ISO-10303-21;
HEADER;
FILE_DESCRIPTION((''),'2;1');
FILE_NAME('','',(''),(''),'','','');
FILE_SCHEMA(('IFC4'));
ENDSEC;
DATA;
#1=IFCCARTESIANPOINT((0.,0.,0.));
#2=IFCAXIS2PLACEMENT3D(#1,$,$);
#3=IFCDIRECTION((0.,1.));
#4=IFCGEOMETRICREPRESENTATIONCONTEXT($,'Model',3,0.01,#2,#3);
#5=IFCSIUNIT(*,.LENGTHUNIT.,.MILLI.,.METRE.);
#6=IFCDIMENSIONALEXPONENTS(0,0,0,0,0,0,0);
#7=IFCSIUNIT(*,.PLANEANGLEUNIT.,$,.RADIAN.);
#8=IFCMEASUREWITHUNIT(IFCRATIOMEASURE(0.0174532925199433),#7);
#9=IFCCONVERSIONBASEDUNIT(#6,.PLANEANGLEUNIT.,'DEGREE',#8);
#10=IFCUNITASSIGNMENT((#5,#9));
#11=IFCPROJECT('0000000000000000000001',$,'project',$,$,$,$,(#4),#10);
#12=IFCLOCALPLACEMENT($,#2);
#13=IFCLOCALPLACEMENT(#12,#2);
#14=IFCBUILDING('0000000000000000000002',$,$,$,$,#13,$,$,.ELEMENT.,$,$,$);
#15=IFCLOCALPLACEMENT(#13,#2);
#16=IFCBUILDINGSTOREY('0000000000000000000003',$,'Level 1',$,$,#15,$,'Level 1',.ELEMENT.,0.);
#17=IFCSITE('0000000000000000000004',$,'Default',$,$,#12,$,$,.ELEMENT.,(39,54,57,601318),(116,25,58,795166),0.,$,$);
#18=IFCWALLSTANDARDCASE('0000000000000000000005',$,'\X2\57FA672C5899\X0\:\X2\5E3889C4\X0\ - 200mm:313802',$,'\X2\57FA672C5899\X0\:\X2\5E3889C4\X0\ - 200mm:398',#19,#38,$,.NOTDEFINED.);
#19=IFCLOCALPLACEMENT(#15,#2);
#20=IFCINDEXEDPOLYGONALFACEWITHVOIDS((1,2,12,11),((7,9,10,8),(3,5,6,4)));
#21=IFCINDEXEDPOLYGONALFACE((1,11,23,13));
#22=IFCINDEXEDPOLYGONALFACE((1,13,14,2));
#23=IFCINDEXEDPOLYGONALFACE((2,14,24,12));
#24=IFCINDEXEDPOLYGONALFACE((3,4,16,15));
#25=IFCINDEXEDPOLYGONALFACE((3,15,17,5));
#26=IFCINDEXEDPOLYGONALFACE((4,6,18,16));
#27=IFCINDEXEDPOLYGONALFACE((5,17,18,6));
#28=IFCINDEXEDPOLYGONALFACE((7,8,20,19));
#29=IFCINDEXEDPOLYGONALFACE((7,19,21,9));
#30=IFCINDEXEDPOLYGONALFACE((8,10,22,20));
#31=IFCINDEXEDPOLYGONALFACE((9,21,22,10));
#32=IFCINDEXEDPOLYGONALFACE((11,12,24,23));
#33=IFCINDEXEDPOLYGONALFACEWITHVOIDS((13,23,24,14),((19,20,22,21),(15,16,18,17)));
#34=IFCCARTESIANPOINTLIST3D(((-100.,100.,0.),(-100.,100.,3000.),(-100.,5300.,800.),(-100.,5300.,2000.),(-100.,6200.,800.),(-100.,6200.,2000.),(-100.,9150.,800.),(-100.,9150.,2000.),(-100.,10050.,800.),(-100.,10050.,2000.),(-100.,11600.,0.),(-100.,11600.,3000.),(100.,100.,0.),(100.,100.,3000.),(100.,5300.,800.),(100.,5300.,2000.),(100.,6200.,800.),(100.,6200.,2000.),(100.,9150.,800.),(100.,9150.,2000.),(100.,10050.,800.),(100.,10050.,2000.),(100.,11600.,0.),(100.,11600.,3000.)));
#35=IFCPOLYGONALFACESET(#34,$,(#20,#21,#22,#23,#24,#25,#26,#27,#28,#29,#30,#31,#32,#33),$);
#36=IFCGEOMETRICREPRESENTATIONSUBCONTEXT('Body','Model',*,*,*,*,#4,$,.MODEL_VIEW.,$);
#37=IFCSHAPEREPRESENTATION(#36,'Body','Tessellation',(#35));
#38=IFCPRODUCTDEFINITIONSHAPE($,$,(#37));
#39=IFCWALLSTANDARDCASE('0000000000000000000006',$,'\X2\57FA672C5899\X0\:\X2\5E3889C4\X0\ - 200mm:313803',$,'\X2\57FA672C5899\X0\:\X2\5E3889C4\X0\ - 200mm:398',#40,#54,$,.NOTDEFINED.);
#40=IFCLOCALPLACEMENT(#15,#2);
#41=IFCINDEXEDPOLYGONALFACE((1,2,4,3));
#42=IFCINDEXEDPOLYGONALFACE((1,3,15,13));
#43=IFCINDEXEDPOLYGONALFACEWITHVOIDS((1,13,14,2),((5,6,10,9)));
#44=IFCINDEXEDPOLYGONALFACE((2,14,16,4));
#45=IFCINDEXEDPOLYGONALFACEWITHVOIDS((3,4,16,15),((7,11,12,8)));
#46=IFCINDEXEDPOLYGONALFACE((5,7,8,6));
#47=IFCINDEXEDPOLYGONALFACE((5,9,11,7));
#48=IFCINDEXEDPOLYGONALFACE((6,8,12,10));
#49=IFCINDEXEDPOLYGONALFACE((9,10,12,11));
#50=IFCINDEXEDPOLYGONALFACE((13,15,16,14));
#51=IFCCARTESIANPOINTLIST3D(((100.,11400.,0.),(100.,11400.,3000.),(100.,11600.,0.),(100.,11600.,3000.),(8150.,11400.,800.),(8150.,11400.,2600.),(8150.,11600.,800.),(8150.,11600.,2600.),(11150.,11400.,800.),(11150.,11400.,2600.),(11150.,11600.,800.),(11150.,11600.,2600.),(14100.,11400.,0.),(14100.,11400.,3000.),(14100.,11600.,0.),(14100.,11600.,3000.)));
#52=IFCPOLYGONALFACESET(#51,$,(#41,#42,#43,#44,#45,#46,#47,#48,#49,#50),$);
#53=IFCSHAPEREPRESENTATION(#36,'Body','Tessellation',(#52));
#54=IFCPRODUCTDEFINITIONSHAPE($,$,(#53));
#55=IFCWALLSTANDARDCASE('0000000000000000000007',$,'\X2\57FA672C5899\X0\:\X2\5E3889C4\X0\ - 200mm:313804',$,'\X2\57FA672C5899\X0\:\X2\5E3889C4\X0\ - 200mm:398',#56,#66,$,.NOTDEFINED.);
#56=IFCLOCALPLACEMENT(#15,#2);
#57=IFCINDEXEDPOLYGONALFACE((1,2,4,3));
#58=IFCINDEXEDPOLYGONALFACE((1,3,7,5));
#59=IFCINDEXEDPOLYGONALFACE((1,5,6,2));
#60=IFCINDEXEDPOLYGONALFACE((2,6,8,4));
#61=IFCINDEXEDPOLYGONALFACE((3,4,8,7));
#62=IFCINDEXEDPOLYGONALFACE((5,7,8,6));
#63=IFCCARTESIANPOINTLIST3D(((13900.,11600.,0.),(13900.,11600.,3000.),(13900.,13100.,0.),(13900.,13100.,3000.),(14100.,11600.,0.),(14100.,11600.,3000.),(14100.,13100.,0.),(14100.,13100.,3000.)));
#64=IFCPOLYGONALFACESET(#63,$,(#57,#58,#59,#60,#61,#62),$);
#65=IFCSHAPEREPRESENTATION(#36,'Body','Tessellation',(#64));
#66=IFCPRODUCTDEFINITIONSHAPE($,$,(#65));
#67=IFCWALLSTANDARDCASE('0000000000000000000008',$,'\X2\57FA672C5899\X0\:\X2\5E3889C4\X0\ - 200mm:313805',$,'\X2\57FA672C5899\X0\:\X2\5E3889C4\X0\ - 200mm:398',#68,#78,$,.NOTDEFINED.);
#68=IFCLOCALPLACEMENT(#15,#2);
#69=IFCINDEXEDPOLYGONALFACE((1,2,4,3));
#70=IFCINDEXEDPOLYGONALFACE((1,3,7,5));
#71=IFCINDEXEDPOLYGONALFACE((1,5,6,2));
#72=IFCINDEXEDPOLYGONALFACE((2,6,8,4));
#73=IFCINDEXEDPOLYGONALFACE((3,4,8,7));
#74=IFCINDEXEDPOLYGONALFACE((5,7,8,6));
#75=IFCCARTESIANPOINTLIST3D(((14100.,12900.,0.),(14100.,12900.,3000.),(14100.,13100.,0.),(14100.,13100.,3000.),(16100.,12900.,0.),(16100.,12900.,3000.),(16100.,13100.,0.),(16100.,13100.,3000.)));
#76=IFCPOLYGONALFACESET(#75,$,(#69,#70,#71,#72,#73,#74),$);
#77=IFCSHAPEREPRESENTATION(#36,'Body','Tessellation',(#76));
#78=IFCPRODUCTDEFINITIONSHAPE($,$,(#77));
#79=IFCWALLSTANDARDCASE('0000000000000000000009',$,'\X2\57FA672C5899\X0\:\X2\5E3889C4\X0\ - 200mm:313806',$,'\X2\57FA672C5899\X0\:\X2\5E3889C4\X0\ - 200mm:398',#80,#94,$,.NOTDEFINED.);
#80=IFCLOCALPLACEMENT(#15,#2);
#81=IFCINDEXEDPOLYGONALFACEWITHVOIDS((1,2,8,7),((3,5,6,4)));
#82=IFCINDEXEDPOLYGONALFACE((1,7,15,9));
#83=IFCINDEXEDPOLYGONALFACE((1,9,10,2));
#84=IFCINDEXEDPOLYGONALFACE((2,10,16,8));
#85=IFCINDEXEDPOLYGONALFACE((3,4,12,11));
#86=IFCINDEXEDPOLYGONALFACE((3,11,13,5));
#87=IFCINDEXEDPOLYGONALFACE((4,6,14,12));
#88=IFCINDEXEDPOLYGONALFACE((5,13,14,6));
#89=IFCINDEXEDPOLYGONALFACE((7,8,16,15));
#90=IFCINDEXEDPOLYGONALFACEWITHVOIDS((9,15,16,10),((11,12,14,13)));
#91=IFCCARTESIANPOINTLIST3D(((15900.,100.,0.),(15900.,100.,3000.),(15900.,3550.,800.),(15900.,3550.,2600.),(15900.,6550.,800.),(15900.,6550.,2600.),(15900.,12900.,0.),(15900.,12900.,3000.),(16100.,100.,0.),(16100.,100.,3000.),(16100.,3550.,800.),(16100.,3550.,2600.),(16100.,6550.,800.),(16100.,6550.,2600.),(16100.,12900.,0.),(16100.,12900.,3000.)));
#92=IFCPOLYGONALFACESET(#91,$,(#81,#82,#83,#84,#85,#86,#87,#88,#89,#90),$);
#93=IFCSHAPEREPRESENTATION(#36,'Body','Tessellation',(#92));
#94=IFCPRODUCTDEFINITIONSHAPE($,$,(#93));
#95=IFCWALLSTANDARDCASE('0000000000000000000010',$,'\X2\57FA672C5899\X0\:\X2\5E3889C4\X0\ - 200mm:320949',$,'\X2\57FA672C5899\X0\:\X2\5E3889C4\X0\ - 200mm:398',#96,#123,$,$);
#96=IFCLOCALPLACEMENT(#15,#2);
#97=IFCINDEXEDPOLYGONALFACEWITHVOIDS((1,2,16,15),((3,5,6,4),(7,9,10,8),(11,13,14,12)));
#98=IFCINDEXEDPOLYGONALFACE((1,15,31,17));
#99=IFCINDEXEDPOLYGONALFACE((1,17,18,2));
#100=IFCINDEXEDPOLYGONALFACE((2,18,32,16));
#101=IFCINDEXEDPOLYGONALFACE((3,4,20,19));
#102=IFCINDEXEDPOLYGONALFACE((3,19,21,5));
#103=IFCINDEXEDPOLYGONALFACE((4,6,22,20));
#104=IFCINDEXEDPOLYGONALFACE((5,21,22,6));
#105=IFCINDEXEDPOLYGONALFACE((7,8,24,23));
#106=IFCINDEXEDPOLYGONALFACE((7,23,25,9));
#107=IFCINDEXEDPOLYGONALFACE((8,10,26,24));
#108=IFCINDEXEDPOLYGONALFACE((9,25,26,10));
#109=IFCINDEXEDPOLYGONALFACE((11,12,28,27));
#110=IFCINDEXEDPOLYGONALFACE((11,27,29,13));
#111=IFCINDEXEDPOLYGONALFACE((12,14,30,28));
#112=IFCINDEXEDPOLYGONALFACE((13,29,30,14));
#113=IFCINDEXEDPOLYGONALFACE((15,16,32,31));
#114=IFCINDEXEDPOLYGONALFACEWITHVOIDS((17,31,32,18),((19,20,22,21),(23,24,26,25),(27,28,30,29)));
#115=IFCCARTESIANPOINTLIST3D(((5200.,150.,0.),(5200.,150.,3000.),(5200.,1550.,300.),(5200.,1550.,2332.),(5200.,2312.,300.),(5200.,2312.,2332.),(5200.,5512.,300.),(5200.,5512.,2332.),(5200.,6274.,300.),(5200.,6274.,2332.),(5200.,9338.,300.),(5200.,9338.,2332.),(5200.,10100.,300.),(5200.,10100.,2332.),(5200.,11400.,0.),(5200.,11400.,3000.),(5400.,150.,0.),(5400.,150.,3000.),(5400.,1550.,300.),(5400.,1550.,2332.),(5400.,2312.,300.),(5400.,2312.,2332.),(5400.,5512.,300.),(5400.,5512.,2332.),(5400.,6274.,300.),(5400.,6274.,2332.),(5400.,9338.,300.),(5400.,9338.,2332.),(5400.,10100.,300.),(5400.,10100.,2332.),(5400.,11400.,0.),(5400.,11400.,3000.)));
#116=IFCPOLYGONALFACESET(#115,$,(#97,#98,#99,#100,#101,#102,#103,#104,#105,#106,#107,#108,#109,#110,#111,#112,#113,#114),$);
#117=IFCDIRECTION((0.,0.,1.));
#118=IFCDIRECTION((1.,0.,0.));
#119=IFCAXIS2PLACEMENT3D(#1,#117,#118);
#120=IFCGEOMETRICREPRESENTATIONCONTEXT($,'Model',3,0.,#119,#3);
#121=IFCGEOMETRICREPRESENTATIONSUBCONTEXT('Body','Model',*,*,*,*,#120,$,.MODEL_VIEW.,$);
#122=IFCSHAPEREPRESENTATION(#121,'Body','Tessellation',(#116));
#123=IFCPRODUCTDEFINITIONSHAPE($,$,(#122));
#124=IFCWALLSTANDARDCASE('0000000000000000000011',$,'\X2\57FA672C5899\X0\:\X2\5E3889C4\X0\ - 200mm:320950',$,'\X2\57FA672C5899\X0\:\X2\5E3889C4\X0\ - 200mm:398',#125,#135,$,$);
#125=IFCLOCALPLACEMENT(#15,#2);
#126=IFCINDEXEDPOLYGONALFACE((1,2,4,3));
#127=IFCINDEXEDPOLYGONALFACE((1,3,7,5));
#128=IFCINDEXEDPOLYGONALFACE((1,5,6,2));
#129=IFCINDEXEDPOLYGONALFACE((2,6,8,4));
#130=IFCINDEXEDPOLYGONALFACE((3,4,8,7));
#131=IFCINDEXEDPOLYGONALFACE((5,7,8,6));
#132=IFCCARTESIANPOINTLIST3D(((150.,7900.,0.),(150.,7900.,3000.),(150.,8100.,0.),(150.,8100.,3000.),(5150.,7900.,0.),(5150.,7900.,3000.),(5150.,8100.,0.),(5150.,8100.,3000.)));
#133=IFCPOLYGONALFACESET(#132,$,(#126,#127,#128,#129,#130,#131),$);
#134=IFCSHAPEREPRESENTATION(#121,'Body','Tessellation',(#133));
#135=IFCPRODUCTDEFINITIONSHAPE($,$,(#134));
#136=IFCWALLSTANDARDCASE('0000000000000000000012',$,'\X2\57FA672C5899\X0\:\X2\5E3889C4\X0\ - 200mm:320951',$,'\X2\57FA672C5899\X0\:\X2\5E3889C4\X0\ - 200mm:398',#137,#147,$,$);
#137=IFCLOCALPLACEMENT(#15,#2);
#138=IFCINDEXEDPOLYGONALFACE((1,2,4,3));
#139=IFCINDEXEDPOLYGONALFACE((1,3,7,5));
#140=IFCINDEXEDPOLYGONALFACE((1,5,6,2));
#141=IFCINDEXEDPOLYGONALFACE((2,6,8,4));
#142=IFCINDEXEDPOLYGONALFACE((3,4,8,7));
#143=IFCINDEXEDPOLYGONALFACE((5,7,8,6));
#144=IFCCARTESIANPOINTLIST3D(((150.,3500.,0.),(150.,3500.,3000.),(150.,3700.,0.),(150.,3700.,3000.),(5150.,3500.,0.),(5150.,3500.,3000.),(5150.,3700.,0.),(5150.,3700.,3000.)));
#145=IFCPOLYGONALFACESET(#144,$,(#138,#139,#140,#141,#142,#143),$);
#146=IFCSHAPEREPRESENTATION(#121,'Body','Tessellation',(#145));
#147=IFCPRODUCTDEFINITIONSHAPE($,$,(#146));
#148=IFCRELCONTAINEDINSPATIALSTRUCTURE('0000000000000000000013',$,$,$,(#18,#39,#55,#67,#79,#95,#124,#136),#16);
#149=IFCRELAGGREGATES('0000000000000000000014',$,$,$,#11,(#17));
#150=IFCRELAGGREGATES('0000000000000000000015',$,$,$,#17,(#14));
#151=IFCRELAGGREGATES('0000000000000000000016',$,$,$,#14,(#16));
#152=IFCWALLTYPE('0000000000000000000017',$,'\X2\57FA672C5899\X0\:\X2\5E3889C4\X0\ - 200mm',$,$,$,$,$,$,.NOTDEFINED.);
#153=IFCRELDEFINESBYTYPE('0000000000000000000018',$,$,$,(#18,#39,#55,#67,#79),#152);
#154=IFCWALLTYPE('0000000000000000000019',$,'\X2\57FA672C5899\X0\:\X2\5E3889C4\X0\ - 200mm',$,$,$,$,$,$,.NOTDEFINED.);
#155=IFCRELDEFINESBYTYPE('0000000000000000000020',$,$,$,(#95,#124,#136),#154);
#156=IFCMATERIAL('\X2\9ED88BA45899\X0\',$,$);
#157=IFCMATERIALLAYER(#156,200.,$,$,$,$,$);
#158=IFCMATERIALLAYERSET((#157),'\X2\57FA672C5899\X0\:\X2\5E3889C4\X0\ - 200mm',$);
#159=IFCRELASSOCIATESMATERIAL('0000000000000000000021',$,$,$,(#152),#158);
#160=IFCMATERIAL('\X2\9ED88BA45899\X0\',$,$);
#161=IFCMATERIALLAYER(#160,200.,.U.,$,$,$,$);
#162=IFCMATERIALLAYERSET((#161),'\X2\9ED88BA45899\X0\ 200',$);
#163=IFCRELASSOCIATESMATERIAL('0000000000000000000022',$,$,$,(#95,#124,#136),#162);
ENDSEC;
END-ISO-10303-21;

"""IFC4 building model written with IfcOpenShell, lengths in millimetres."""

from ifc_helpers import new_model, entity, si_unit, converted_unit, direction, frame, frame_2d, origin, origin_with_axes, place, context, subcontext, project, spatial, polyline, rectangle, outline, extrude, material, layer, layer_set, layer_usage, type_object, element, save


model = new_model("IFC4")

# Units and contexts
model_context_1 = context("Model", 3, precision=0.01, world=origin(), true_north=direction((0.0, 1.0)))
model_context_2 = context("Model", 3, precision=0.0, world=origin_with_axes(), true_north=direction((0.0, 1.0)))
body_context_1 = subcontext(model_context_1, "Body", "Model", "MODEL_VIEW")
body_context_2 = subcontext(model_context_2, "Body", "Model", "MODEL_VIEW")
ifc_project = project(units=[si_unit("LENGTHUNIT", "METRE", prefix="MILLI"), converted_unit("PLANEANGLEUNIT", "DEGREE", entity("IfcRatioMeasure", 0.0174532925199433), si_unit("PLANEANGLEUNIT", "RADIAN"), dimensions=[0, 0, 0, 0, 0, 0, 0])], contexts=[model_context_1])

# Site, building, storey
site_placement = place(None, origin())
site = spatial("IfcSite", under=ifc_project, at=site_placement, Name="Default", CompositionType="ELEMENT", RefLatitude=(39, 54, 57, 601318), RefLongitude=(116, 25, 58, 795166), RefElevation=0.0)
building_placement = place(site_placement, origin())
building = spatial("IfcBuilding", under=site, at=building_placement, CompositionType="ELEMENT")
storey_placement = place(building_placement, origin())
storey = spatial("IfcBuildingStorey", under=building, at=storey_placement, Name="Level 1", LongName="Level 1", CompositionType="ELEMENT", Elevation=0.0)

# Wall, openings
ifc_material_1 = material(Name="默认墙")
ifc_layer_1 = layer(ifc_material_1, 200.0)
ifc_layer_set_1 = layer_set([ifc_layer_1], Name="基本墙:常规 - 200mm")
wall_type_1 = type_object("IfcWallType", Name="基本墙:常规 - 200mm", PredefinedType="NOTDEFINED", material=ifc_layer_set_1)
placement_1 = place(None, origin_with_axes())
placement_2 = place(placement_1, origin_with_axes())
placement_3 = place(placement_2, origin_with_axes())
wall_1_placement = place(storey_placement, frame((0.0, 100.0, 0.0), z_axis=(0.0, 0.0, 1.0), x_axis=(0.0, 1.0, 0.0)))
wall_1 = element("IfcWallStandardCase", 1, at=wall_1_placement, inside=storey, type_object=wall_type_1, Name="基本墙:常规 - 200mm:313802", ObjectType="基本墙:常规 - 200mm:398", PredefinedType="NOTDEFINED", context=body_context_1, shape_type="SweptSolid", body=[
    extrude(rectangle(XDim=11500.0, YDim=200.0, at=frame_2d((5750.0, 0.0), x_axis=(-1.0, 0.0))), origin(), (0.0, 0.0, 1.0), 3000.0),
])
placement_4 = place(placement_3, frame((0.0, 0.0, 0.0), z_axis=(0.0, 0.0, 1.0), x_axis=(0.0, 1.0, 0.0)))
opening_1_placement = place(placement_4, frame((5750.0, 0.0, 800.0), z_axis=(0.0, 0.0, 1.0), x_axis=(1.0, 0.0, 0.0)))
element("IfcOpeningElement", 2, at=opening_1_placement, cuts=wall_1, context=body_context_2, shape_type="SweptSolid", body=[
    extrude(outline(polyline([(450.0, -1200.0), (450.0, 0.0), (-450.0, 0.0), (-450.0, -1200.0), (450.0, -1200.0)])), frame((0.0, 100.0, 0.0), z_axis=(0.0, -1.0, 0.0), x_axis=(-1.0, 0.0, 0.0)), (0.0, 0.0, 1.0), 200.0),
])
opening_2_placement = place(placement_4, frame((9600.0, 0.0, 800.0), z_axis=(0.0, 0.0, 1.0), x_axis=(1.0, 0.0, 0.0)))
element("IfcOpeningElement", 3, at=opening_2_placement, cuts=wall_1, context=body_context_2, shape_type="SweptSolid", body=[
    extrude(outline(polyline([(450.0, -1200.0), (450.0, 0.0), (-450.0, 0.0), (-450.0, -1200.0), (450.0, -1200.0)])), frame((0.0, 100.0, 0.0), z_axis=(0.0, -1.0, 0.0), x_axis=(-1.0, 0.0, 0.0)), (0.0, 0.0, 1.0), 200.0),
])

# Wall, opening
wall_2_placement = place(storey_placement, frame((100.0, 11500.0, 0.0)))
wall_2 = element("IfcWallStandardCase", 4, at=wall_2_placement, inside=storey, type_object=wall_type_1, Name="基本墙:常规 - 200mm:313803", ObjectType="基本墙:常规 - 200mm:398", PredefinedType="NOTDEFINED", context=body_context_1, shape_type="SweptSolid", body=[
    extrude(rectangle(XDim=14000.0, YDim=200.0, at=frame_2d((7000.0, 0.0), x_axis=(-1.0, 0.0))), origin(), (0.0, 0.0, 1.0), 3000.0),
])
placement_5 = place(placement_3, frame((0.0, 11500.0, 0.0), z_axis=(0.0, 0.0, 1.0), x_axis=(1.0, 0.0, 0.0)))
opening_3_placement = place(placement_5, frame((9650.0, 0.0, 800.0), z_axis=(0.0, 0.0, 1.0), x_axis=(1.0, 0.0, 0.0)))
element("IfcOpeningElement", 5, at=opening_3_placement, cuts=wall_2, context=body_context_2, shape_type="SweptSolid", body=[
    extrude(outline(polyline([(-1500.0, 0.0), (-1500.0, -1800.0), (1500.0, -1800.0), (1500.0, 0.0), (-1500.0, 0.0)])), frame((0.0, -100.0, 0.0), z_axis=(0.0, 1.0, 0.0), x_axis=(1.0, 0.0, 0.0)), (0.0, 0.0, 1.0), 200.0),
])

# Walls
wall_3_placement = place(storey_placement, frame((14000.0, 11600.0, 0.0), z_axis=(0.0, 0.0, 1.0), x_axis=(0.0, 1.0, 0.0)))
element("IfcWallStandardCase", 6, at=wall_3_placement, inside=storey, type_object=wall_type_1, Name="基本墙:常规 - 200mm:313804", ObjectType="基本墙:常规 - 200mm:398", PredefinedType="NOTDEFINED", context=body_context_1, shape_type="SweptSolid", body=[
    extrude(rectangle(XDim=1500.0, YDim=200.0, at=frame_2d((750.0, 0.0), x_axis=(-1.0, 0.0))), origin(), (0.0, 0.0, 1.0), 3000.0),
])
wall_4_placement = place(storey_placement, frame((14100.0, 13000.0, 0.0)))
element("IfcWallStandardCase", 7, at=wall_4_placement, inside=storey, type_object=wall_type_1, Name="基本墙:常规 - 200mm:313805", ObjectType="基本墙:常规 - 200mm:398", PredefinedType="NOTDEFINED", context=body_context_1, shape_type="SweptSolid", body=[
    extrude(rectangle(XDim=2000.0, YDim=200.0, at=frame_2d((1000.0, 0.0), x_axis=(-1.0, 0.0))), origin(), (0.0, 0.0, 1.0), 3000.0),
])

# Wall, opening
wall_5_placement = place(storey_placement, frame((16000.0, 12900.0, 0.0), z_axis=(0.0, 0.0, 1.0), x_axis=(0.0, -1.0, 0.0)))
wall_5 = element("IfcWallStandardCase", 8, at=wall_5_placement, inside=storey, type_object=wall_type_1, Name="基本墙:常规 - 200mm:313806", ObjectType="基本墙:常规 - 200mm:398", PredefinedType="NOTDEFINED", context=body_context_1, shape_type="SweptSolid", body=[
    extrude(rectangle(XDim=12800.0, YDim=200.0, at=frame_2d((6400.0, 0.0), x_axis=(-1.0, 0.0))), origin(), (0.0, 0.0, 1.0), 3000.0),
])
placement_6 = place(placement_3, frame((16000.0, 13000.0, 0.0), z_axis=(0.0, 0.0, 1.0), x_axis=(0.0, -1.0, 0.0)))
opening_4_placement = place(placement_6, frame((7950.0, 0.0, 800.0), z_axis=(0.0, 0.0, 1.0), x_axis=(1.0, 0.0, 0.0)))
element("IfcOpeningElement", 9, at=opening_4_placement, cuts=wall_5, context=body_context_2, shape_type="SweptSolid", body=[
    extrude(outline(polyline([(-1500.0, 0.0), (-1500.0, -1800.0), (1500.0, -1800.0), (1500.0, 0.0), (-1500.0, 0.0)])), frame((0.0, -100.0, 0.0), z_axis=(0.0, 1.0, 0.0), x_axis=(1.0, 0.0, 0.0)), (0.0, 0.0, 1.0), 200.0),
])

# Wall, openings
ifc_material_2 = material(Name="默认墙")
ifc_layer_2 = layer(ifc_material_2, 200.0, ventilated="UNKNOWN")
ifc_layer_set_2 = layer_set([ifc_layer_2], Name="默认墙 200")
ifc_layer_usage_1 = layer_usage(ifc_layer_set_2, "AXIS2", "POSITIVE", -100.0)
wall_type_2 = type_object("IfcWallType", Name="基本墙:常规 - 200mm", PredefinedType="NOTDEFINED")
wall_6_placement = place(placement_3, frame((5300.0, 11500.0, 0.0), z_axis=(0.0, 0.0, 1.0), x_axis=(0.0, -1.0, 0.0)))
wall_6 = element("IfcWallStandardCase", 10, at=wall_6_placement, inside=storey, type_object=wall_type_2, material=ifc_layer_usage_1, Name="基本墙:常规 - 200mm:320949", ObjectType="基本墙:常规 - 200mm:398", context=body_context_2, shape_type="SweptSolid", body=[
    extrude(outline(polyline([(100.0, -100.0), (11350.0, -100.0), (11350.0, 100.0), (100.0, 100.0), (100.0, -100.0)])), origin_with_axes(), (0.0, 0.0, 1.0), 3000.0),
])
opening_5_placement = place(wall_6_placement, frame((9569.0, 0.0, 300.0), z_axis=(0.0, 0.0, 1.0), x_axis=(1.0, 0.0, 0.0)))
element("IfcOpeningElement", 11, at=opening_5_placement, cuts=wall_6, context=body_context_2, shape_type="SweptSolid", body=[
    extrude(outline(polyline([(-381.0, -2032.0), (381.0, -2032.0), (381.0, 0.0), (-381.0, 0.0), (-381.0, -2032.0)])), frame((0.0, -100.0, 0.0), z_axis=(0.0, 1.0, 0.0), x_axis=(1.0, 0.0, 0.0)), (0.0, 0.0, 1.0), 200.0),
])
opening_6_placement = place(wall_6_placement, frame((5607.0, 0.0, 300.0), z_axis=(0.0, 0.0, 1.0), x_axis=(1.0, 0.0, 0.0)))
element("IfcOpeningElement", 12, at=opening_6_placement, cuts=wall_6, context=body_context_2, shape_type="SweptSolid", body=[
    extrude(outline(polyline([(-381.0, -2032.0), (381.0, -2032.0), (381.0, 0.0), (-381.0, 0.0), (-381.0, -2032.0)])), frame((0.0, -100.0, 0.0), z_axis=(0.0, 1.0, 0.0), x_axis=(1.0, 0.0, 0.0)), (0.0, 0.0, 1.0), 200.0),
])
opening_7_placement = place(wall_6_placement, frame((1781.0, 0.0, 300.0), z_axis=(0.0, 0.0, 1.0), x_axis=(1.0, 0.0, 0.0)))
element("IfcOpeningElement", 13, at=opening_7_placement, cuts=wall_6, context=body_context_2, shape_type="SweptSolid", body=[
    extrude(outline(polyline([(-381.0, -2032.0), (381.0, -2032.0), (381.0, 0.0), (-381.0, 0.0), (-381.0, -2032.0)])), frame((0.0, -100.0, 0.0), z_axis=(0.0, 1.0, 0.0), x_axis=(1.0, 0.0, 0.0)), (0.0, 0.0, 1.0), 200.0),
])

# Walls
ifc_layer_usage_2 = layer_usage(ifc_layer_set_2, "AXIS2", "POSITIVE", -100.0)
wall_7_placement = place(placement_3, frame((150.0, 8000.0, 0.0), z_axis=(0.0, 0.0, 1.0), x_axis=(1.0, 0.0, 0.0)))
element("IfcWallStandardCase", 14, at=wall_7_placement, inside=storey, type_object=wall_type_2, material=ifc_layer_usage_2, Name="基本墙:常规 - 200mm:320950", ObjectType="基本墙:常规 - 200mm:398", context=body_context_2, shape_type="SweptSolid", body=[
    extrude(outline(polyline([(0.0, -100.0), (5000.0, -100.0), (5000.0, 100.0), (0.0, 100.0), (0.0, -100.0)])), origin_with_axes(), (0.0, 0.0, 1.0), 3000.0),
])
ifc_layer_usage_3 = layer_usage(ifc_layer_set_2, "AXIS2", "POSITIVE", -100.0)
wall_8_placement = place(placement_3, frame((150.0, 3600.0, 0.0), z_axis=(0.0, 0.0, 1.0), x_axis=(1.0, 0.0, 0.0)))
element("IfcWallStandardCase", 15, at=wall_8_placement, inside=storey, type_object=wall_type_2, material=ifc_layer_usage_3, Name="基本墙:常规 - 200mm:320951", ObjectType="基本墙:常规 - 200mm:398", context=body_context_2, shape_type="SweptSolid", body=[
    extrude(outline(polyline([(0.0, -100.0), (5000.0, -100.0), (5000.0, 100.0), (0.0, 100.0), (0.0, -100.0)])), origin_with_axes(), (0.0, 0.0, 1.0), 3000.0),
])

save(model, "model.ifc")
